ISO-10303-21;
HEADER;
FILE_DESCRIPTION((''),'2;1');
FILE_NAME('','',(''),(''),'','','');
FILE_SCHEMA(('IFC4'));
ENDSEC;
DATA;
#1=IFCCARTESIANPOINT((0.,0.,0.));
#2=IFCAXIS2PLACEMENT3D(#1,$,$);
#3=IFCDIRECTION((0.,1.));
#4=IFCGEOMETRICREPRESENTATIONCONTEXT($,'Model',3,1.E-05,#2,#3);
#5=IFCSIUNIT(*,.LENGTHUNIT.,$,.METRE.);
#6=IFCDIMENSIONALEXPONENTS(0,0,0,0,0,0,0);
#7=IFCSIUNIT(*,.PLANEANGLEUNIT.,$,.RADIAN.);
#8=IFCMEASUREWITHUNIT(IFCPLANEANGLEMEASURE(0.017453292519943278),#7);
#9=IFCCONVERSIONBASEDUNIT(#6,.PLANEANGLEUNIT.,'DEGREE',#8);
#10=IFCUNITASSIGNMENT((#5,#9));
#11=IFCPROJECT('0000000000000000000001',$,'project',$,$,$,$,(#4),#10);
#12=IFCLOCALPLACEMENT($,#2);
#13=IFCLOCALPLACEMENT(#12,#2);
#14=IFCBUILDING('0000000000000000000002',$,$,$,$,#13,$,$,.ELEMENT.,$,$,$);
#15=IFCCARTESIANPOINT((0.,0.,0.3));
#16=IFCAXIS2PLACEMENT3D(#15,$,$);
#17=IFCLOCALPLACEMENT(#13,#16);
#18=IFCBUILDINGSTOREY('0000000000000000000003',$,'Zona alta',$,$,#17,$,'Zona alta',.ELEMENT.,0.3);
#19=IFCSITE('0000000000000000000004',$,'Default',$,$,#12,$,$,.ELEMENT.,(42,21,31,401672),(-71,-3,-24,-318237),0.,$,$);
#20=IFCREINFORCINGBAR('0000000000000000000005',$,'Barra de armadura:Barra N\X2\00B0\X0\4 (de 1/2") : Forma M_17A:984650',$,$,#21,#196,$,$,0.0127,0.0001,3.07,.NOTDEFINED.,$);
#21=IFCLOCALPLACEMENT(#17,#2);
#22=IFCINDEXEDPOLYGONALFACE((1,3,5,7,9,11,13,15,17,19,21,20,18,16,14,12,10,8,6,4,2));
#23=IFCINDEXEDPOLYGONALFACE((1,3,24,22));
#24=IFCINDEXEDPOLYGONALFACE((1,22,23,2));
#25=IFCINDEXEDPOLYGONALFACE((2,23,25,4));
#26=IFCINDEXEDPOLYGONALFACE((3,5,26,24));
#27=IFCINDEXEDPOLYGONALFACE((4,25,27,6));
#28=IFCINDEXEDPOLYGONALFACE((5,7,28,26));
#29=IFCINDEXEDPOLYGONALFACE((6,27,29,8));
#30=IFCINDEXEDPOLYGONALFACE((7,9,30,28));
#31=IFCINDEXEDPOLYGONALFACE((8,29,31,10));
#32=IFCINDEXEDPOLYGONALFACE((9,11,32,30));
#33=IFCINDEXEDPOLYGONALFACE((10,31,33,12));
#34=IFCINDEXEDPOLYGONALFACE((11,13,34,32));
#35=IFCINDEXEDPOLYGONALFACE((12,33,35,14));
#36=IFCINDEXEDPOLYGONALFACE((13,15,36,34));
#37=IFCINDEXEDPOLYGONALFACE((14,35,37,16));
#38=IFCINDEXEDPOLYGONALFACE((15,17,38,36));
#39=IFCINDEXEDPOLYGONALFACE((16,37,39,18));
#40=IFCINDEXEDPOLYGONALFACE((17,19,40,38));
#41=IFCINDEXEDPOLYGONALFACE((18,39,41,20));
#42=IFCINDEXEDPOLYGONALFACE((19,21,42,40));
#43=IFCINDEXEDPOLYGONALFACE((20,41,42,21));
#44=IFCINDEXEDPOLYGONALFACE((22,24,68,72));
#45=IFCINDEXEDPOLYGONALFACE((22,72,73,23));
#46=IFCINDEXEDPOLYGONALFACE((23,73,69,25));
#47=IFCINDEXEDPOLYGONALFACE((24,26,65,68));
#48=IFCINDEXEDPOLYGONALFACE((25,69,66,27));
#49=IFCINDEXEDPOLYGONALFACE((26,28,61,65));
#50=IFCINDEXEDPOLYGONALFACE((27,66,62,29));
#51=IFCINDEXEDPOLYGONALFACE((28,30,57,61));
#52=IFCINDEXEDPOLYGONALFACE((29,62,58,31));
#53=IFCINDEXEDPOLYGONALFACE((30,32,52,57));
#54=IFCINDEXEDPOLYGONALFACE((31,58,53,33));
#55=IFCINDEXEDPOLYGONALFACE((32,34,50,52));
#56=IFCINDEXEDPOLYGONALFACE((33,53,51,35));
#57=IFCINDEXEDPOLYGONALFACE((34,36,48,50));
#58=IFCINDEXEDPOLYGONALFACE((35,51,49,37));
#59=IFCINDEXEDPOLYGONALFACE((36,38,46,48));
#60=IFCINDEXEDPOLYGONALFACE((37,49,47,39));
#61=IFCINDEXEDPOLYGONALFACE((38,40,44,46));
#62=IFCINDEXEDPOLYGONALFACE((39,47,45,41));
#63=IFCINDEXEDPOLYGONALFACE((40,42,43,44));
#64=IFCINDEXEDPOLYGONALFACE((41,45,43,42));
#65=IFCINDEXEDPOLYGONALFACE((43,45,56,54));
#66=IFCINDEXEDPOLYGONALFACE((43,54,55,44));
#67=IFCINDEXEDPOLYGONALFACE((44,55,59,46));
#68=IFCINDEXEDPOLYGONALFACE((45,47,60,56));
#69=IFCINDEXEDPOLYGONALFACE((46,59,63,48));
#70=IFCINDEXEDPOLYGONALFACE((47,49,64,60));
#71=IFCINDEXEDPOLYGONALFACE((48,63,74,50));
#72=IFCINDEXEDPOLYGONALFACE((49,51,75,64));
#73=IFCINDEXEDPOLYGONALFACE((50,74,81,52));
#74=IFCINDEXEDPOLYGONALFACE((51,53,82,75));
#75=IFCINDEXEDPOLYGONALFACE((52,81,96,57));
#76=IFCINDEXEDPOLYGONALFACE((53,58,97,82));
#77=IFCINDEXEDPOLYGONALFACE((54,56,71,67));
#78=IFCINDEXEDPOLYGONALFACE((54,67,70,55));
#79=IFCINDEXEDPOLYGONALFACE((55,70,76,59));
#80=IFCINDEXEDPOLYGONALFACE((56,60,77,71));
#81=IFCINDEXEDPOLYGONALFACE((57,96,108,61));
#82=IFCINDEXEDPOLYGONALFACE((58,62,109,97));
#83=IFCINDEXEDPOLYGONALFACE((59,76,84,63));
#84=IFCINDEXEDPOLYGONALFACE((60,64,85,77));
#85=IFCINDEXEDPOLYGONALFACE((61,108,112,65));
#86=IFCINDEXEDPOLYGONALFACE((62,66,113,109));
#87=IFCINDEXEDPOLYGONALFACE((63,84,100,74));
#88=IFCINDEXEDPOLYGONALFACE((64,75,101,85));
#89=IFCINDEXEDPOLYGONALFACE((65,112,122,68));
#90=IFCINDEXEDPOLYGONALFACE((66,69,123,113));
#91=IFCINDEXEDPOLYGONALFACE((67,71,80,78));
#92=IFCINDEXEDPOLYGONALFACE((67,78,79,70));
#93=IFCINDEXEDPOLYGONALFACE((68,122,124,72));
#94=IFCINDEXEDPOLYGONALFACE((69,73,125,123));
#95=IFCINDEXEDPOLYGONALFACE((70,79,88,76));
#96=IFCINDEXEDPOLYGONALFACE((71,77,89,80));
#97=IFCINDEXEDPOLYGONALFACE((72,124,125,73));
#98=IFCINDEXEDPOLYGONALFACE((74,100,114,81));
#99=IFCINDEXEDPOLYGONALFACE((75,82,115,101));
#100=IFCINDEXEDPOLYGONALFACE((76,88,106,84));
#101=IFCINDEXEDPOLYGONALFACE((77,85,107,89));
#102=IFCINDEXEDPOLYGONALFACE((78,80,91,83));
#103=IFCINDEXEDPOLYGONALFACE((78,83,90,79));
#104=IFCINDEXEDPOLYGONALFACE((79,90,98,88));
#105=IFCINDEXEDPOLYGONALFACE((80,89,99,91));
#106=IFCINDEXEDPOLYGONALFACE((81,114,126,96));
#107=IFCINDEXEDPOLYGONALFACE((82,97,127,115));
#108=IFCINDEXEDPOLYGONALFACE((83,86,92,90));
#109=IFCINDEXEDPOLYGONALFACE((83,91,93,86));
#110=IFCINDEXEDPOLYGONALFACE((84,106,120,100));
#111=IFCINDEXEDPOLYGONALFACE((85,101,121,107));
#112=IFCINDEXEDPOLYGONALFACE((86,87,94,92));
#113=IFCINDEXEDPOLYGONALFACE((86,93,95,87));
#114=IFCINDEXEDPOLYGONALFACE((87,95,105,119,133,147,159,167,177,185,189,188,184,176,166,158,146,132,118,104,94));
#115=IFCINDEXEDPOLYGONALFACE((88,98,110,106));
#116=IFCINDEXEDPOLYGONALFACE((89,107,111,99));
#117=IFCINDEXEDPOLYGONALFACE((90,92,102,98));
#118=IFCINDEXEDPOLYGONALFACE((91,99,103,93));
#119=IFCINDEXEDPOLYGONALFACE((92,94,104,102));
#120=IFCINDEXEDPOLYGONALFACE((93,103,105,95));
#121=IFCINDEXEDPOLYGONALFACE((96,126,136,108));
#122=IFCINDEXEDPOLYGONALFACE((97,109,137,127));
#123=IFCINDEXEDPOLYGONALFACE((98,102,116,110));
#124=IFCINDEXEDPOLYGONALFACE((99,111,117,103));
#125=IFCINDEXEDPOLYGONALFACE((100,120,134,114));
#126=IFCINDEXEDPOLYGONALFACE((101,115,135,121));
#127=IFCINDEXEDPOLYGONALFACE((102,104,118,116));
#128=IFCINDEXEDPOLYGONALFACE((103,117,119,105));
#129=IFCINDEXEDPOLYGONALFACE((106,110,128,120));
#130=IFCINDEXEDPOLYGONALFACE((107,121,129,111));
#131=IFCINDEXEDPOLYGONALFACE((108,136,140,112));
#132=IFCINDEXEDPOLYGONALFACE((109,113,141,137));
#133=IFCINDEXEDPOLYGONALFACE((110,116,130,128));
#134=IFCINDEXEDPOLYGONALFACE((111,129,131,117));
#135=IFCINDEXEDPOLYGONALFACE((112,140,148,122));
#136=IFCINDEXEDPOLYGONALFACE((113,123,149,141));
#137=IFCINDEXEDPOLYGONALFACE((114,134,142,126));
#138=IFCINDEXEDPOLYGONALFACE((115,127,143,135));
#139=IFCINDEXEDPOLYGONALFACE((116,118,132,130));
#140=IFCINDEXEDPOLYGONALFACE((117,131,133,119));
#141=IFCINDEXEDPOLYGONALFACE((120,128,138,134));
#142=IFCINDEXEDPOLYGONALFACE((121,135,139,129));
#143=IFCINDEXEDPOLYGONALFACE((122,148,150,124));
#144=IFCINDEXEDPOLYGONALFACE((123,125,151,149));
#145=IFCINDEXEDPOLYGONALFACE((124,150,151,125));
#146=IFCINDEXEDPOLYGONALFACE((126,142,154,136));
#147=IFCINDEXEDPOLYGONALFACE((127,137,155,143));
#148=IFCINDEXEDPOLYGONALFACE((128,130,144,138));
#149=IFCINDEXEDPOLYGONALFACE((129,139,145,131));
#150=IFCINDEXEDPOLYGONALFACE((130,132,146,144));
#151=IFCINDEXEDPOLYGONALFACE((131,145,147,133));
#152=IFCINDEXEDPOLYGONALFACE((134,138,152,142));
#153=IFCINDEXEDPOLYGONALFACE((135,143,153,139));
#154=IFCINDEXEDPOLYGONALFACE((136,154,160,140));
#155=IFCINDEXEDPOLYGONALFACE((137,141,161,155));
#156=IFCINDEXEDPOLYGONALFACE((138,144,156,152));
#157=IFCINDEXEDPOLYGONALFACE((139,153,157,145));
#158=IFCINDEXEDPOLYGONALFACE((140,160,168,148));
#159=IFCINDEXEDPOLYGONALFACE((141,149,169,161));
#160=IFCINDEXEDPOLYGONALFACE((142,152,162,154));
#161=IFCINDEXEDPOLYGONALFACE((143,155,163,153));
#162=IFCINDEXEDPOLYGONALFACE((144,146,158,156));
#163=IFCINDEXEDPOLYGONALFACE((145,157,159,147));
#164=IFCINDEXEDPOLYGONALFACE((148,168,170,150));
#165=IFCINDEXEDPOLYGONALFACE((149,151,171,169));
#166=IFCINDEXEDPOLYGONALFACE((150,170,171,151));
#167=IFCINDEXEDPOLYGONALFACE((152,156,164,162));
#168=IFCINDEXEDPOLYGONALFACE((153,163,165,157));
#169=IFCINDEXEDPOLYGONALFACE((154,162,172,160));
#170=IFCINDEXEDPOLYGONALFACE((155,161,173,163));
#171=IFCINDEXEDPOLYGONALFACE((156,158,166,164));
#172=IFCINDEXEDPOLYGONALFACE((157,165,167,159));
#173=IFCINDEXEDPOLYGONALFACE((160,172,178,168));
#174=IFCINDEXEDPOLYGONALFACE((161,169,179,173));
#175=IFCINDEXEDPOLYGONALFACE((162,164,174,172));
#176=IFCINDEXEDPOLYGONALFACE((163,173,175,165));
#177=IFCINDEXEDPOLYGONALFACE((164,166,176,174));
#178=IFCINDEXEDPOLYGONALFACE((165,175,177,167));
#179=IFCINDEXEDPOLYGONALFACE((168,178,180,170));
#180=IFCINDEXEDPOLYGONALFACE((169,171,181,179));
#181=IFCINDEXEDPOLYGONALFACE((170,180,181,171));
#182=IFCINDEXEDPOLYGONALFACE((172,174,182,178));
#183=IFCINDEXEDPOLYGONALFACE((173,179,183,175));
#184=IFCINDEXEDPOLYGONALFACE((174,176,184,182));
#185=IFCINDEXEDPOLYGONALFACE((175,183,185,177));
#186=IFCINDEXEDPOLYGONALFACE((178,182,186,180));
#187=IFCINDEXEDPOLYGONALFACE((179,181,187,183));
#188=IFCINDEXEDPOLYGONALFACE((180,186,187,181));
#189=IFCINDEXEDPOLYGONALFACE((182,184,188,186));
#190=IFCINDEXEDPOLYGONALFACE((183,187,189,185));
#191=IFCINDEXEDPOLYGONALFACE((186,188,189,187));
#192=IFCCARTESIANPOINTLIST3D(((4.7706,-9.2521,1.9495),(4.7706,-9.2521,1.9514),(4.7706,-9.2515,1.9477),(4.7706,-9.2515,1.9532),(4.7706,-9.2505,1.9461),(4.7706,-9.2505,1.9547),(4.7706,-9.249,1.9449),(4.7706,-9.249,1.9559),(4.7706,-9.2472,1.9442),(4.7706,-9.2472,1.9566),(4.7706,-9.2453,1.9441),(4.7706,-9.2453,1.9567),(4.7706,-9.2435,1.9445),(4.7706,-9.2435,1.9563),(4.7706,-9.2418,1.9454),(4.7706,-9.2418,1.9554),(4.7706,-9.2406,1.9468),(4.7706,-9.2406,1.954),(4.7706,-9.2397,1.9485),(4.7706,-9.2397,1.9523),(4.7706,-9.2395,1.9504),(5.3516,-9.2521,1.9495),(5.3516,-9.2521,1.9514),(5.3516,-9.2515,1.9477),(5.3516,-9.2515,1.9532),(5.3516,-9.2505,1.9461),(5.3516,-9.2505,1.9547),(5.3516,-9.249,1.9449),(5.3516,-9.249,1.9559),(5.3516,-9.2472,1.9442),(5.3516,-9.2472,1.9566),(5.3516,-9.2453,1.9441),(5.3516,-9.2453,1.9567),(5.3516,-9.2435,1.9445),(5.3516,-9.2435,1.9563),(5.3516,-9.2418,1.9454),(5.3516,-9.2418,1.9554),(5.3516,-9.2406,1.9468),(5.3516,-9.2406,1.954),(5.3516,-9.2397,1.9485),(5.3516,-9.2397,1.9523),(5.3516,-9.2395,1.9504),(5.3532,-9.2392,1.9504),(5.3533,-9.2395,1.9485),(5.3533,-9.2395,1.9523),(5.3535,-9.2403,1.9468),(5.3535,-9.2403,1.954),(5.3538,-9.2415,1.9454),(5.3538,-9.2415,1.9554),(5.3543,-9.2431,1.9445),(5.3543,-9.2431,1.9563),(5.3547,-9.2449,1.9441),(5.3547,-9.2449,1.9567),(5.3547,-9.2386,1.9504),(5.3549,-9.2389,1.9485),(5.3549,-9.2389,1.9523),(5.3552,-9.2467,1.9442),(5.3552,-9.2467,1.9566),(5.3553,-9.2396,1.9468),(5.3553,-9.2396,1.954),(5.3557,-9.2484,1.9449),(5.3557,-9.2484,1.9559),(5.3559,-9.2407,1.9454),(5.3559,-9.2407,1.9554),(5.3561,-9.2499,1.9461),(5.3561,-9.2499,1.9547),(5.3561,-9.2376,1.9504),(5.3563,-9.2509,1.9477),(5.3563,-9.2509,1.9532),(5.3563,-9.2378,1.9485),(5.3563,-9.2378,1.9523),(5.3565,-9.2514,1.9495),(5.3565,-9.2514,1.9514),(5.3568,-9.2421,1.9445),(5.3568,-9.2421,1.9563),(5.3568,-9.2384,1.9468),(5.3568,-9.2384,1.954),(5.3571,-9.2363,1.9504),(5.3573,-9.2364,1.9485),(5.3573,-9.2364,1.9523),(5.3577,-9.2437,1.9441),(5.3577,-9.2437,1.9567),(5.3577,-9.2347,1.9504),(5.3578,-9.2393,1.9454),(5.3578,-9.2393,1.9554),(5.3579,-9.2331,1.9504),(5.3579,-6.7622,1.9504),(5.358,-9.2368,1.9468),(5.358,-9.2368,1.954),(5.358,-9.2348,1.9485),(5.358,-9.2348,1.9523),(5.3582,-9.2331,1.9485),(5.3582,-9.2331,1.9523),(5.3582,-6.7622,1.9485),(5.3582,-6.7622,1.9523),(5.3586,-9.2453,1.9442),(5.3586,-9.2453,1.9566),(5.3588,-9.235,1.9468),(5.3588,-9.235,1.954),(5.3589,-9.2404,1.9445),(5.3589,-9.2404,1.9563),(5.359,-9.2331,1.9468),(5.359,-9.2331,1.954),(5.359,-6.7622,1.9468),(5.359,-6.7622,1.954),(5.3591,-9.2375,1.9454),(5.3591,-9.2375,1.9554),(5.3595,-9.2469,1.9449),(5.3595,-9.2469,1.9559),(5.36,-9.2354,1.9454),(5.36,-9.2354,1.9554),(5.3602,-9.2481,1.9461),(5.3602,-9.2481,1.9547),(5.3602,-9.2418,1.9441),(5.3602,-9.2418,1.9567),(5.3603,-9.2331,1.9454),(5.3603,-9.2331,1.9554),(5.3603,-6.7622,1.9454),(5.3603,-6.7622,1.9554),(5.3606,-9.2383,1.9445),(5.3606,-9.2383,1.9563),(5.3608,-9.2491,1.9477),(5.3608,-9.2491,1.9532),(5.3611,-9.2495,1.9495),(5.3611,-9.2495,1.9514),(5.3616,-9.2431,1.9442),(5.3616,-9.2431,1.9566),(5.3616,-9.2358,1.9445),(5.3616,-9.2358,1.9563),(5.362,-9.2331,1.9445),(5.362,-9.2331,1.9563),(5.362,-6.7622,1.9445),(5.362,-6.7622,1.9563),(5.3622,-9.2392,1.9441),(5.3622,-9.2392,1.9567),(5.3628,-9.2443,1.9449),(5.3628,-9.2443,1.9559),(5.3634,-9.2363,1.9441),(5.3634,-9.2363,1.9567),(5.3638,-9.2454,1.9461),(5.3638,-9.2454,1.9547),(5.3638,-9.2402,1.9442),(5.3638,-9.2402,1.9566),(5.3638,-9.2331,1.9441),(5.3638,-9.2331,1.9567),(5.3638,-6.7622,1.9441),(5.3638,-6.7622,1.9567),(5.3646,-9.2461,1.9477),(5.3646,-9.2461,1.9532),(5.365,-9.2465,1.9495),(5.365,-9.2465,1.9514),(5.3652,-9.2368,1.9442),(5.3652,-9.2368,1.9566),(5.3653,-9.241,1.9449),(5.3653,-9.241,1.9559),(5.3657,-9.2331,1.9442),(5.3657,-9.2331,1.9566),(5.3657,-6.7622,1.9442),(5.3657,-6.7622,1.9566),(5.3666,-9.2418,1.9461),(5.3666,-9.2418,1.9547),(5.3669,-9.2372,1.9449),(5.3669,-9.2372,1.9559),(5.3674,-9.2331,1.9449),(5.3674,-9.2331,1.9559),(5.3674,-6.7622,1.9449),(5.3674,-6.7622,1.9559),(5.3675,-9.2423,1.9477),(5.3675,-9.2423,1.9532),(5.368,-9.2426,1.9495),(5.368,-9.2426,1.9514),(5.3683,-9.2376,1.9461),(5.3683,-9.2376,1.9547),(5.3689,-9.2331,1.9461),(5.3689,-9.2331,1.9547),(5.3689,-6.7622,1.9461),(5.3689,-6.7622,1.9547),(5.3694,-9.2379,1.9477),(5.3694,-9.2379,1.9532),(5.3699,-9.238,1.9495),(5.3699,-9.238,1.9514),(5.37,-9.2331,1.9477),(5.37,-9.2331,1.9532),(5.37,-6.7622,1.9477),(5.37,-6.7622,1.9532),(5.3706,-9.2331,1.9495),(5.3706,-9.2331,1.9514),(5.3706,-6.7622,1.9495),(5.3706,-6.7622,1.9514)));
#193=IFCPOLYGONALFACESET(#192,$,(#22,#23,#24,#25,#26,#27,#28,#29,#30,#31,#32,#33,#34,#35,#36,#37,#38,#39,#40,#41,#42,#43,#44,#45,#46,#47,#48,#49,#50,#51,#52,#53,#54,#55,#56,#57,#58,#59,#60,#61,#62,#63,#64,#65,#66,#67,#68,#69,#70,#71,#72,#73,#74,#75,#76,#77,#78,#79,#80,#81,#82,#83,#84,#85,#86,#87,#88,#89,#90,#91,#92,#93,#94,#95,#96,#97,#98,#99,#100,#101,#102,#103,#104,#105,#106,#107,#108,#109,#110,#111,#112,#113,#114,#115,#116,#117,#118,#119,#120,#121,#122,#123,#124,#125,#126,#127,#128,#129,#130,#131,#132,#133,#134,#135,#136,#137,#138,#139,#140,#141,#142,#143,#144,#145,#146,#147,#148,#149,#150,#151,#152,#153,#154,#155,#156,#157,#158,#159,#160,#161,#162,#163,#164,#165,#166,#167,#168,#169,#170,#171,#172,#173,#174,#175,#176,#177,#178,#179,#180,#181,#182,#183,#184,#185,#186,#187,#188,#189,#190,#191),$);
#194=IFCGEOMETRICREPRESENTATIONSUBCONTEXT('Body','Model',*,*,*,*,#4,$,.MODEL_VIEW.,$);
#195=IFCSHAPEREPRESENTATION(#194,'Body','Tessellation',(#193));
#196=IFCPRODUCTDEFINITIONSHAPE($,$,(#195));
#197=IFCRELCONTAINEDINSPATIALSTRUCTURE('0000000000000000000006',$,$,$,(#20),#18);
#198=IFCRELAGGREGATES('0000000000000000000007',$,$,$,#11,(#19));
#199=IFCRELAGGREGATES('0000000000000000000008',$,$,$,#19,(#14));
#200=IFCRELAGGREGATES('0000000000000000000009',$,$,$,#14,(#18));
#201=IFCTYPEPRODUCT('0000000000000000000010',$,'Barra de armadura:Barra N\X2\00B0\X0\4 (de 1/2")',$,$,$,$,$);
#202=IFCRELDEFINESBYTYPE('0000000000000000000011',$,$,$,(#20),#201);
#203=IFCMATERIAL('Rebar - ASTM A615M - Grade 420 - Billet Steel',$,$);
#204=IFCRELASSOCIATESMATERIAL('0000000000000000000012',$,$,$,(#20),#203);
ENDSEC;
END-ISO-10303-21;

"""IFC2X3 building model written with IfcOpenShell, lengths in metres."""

from ifc_helpers import new_model, entity, si_unit, converted_unit, direction, frame, origin, place, context, subcontext, project, spatial, material, type_object, element, save


model = new_model("IFC2X3")

# Units and contexts
model_context = context("Model", 3, precision=1e-05, world=origin(), true_north=direction((0.0, 1.0)))
body_context = subcontext(model_context, "Body", "Model", "MODEL_VIEW")
ifc_project = project(units=[si_unit("LENGTHUNIT", "METRE"), converted_unit("PLANEANGLEUNIT", "DEGREE", entity("IfcPlaneAngleMeasure", 0.017453292519943278), si_unit("PLANEANGLEUNIT", "RADIAN"), dimensions=[0, 0, 0, 0, 0, 0, 0])], contexts=[model_context])

# Site, building, storey
site_placement = place(None, origin())
site = spatial("IfcSite", under=ifc_project, at=site_placement, Name="Default", CompositionType="ELEMENT", RefLatitude=(42, 21, 31, 401672), RefLongitude=(-71, -3, -24, -318237), RefElevation=0.0)
building_placement = place(site_placement, origin())
building = spatial("IfcBuilding", under=site, at=building_placement, CompositionType="ELEMENT")
storey_placement = place(building_placement, frame((0.0, 0.0, 0.3)))
storey = spatial("IfcBuildingStorey", under=building, at=storey_placement, Name="Zona alta", LongName="Zona alta", CompositionType="ELEMENT", Elevation=0.3)

# Reinforcing bar
ifc_material_1 = material(Name="Rebar - ASTM A615M - Grade 420 - Billet Steel")
type_product_1 = type_object("IfcTypeProduct", Name="Barra de armadura:Barra N°4 (de 1/2\")")
reinforcing_bar_1_placement = place(storey_placement, origin())
element("IfcReinforcingBar", 1, at=reinforcing_bar_1_placement, inside=storey, type_object=type_product_1, material=ifc_material_1, Name="Barra de armadura:Barra N°4 (de 1/2\") : Forma M_17A:984650", BarLength=3.07, BarRole="NOTDEFINED", CrossSectionArea=0.0001, NominalDiameter=0.0127, context=body_context, shape_type="AdvancedSweptSolid", body=[
    entity("IfcSweptDiskSolid", entity("IfcCompositeCurve", [entity("IfcCompositeCurveSegment", "CONTINUOUS", True, entity("IfcPolyline", [entity("IfcCartesianPoint", [4.7706, -9.2458, 1.9504]), entity("IfcCartesianPoint", [5.3516, -9.2458, 1.9504])])), entity("IfcCompositeCurveSegment", "CONTINUOUS", True, entity("IfcTrimmedCurve", entity("IfcCircle", entity("IfcAxis2Placement3D", entity("IfcCartesianPoint", [5.3516, -9.2331, 1.9504])), 0.0127), [entity("IfcParameterValue", 270.0)], [entity("IfcParameterValue", 360.0)], True, "PARAMETER")), entity("IfcCompositeCurveSegment", "CONTINUOUS", True, entity("IfcPolyline", [entity("IfcCartesianPoint", [5.3643, -9.2331, 1.9504]), entity("IfcCartesianPoint", [5.3643, -6.7622, 1.9504])]))], False), 0.0063, None, 0.0, 92.0),
])

save(model, "model.ifc")
